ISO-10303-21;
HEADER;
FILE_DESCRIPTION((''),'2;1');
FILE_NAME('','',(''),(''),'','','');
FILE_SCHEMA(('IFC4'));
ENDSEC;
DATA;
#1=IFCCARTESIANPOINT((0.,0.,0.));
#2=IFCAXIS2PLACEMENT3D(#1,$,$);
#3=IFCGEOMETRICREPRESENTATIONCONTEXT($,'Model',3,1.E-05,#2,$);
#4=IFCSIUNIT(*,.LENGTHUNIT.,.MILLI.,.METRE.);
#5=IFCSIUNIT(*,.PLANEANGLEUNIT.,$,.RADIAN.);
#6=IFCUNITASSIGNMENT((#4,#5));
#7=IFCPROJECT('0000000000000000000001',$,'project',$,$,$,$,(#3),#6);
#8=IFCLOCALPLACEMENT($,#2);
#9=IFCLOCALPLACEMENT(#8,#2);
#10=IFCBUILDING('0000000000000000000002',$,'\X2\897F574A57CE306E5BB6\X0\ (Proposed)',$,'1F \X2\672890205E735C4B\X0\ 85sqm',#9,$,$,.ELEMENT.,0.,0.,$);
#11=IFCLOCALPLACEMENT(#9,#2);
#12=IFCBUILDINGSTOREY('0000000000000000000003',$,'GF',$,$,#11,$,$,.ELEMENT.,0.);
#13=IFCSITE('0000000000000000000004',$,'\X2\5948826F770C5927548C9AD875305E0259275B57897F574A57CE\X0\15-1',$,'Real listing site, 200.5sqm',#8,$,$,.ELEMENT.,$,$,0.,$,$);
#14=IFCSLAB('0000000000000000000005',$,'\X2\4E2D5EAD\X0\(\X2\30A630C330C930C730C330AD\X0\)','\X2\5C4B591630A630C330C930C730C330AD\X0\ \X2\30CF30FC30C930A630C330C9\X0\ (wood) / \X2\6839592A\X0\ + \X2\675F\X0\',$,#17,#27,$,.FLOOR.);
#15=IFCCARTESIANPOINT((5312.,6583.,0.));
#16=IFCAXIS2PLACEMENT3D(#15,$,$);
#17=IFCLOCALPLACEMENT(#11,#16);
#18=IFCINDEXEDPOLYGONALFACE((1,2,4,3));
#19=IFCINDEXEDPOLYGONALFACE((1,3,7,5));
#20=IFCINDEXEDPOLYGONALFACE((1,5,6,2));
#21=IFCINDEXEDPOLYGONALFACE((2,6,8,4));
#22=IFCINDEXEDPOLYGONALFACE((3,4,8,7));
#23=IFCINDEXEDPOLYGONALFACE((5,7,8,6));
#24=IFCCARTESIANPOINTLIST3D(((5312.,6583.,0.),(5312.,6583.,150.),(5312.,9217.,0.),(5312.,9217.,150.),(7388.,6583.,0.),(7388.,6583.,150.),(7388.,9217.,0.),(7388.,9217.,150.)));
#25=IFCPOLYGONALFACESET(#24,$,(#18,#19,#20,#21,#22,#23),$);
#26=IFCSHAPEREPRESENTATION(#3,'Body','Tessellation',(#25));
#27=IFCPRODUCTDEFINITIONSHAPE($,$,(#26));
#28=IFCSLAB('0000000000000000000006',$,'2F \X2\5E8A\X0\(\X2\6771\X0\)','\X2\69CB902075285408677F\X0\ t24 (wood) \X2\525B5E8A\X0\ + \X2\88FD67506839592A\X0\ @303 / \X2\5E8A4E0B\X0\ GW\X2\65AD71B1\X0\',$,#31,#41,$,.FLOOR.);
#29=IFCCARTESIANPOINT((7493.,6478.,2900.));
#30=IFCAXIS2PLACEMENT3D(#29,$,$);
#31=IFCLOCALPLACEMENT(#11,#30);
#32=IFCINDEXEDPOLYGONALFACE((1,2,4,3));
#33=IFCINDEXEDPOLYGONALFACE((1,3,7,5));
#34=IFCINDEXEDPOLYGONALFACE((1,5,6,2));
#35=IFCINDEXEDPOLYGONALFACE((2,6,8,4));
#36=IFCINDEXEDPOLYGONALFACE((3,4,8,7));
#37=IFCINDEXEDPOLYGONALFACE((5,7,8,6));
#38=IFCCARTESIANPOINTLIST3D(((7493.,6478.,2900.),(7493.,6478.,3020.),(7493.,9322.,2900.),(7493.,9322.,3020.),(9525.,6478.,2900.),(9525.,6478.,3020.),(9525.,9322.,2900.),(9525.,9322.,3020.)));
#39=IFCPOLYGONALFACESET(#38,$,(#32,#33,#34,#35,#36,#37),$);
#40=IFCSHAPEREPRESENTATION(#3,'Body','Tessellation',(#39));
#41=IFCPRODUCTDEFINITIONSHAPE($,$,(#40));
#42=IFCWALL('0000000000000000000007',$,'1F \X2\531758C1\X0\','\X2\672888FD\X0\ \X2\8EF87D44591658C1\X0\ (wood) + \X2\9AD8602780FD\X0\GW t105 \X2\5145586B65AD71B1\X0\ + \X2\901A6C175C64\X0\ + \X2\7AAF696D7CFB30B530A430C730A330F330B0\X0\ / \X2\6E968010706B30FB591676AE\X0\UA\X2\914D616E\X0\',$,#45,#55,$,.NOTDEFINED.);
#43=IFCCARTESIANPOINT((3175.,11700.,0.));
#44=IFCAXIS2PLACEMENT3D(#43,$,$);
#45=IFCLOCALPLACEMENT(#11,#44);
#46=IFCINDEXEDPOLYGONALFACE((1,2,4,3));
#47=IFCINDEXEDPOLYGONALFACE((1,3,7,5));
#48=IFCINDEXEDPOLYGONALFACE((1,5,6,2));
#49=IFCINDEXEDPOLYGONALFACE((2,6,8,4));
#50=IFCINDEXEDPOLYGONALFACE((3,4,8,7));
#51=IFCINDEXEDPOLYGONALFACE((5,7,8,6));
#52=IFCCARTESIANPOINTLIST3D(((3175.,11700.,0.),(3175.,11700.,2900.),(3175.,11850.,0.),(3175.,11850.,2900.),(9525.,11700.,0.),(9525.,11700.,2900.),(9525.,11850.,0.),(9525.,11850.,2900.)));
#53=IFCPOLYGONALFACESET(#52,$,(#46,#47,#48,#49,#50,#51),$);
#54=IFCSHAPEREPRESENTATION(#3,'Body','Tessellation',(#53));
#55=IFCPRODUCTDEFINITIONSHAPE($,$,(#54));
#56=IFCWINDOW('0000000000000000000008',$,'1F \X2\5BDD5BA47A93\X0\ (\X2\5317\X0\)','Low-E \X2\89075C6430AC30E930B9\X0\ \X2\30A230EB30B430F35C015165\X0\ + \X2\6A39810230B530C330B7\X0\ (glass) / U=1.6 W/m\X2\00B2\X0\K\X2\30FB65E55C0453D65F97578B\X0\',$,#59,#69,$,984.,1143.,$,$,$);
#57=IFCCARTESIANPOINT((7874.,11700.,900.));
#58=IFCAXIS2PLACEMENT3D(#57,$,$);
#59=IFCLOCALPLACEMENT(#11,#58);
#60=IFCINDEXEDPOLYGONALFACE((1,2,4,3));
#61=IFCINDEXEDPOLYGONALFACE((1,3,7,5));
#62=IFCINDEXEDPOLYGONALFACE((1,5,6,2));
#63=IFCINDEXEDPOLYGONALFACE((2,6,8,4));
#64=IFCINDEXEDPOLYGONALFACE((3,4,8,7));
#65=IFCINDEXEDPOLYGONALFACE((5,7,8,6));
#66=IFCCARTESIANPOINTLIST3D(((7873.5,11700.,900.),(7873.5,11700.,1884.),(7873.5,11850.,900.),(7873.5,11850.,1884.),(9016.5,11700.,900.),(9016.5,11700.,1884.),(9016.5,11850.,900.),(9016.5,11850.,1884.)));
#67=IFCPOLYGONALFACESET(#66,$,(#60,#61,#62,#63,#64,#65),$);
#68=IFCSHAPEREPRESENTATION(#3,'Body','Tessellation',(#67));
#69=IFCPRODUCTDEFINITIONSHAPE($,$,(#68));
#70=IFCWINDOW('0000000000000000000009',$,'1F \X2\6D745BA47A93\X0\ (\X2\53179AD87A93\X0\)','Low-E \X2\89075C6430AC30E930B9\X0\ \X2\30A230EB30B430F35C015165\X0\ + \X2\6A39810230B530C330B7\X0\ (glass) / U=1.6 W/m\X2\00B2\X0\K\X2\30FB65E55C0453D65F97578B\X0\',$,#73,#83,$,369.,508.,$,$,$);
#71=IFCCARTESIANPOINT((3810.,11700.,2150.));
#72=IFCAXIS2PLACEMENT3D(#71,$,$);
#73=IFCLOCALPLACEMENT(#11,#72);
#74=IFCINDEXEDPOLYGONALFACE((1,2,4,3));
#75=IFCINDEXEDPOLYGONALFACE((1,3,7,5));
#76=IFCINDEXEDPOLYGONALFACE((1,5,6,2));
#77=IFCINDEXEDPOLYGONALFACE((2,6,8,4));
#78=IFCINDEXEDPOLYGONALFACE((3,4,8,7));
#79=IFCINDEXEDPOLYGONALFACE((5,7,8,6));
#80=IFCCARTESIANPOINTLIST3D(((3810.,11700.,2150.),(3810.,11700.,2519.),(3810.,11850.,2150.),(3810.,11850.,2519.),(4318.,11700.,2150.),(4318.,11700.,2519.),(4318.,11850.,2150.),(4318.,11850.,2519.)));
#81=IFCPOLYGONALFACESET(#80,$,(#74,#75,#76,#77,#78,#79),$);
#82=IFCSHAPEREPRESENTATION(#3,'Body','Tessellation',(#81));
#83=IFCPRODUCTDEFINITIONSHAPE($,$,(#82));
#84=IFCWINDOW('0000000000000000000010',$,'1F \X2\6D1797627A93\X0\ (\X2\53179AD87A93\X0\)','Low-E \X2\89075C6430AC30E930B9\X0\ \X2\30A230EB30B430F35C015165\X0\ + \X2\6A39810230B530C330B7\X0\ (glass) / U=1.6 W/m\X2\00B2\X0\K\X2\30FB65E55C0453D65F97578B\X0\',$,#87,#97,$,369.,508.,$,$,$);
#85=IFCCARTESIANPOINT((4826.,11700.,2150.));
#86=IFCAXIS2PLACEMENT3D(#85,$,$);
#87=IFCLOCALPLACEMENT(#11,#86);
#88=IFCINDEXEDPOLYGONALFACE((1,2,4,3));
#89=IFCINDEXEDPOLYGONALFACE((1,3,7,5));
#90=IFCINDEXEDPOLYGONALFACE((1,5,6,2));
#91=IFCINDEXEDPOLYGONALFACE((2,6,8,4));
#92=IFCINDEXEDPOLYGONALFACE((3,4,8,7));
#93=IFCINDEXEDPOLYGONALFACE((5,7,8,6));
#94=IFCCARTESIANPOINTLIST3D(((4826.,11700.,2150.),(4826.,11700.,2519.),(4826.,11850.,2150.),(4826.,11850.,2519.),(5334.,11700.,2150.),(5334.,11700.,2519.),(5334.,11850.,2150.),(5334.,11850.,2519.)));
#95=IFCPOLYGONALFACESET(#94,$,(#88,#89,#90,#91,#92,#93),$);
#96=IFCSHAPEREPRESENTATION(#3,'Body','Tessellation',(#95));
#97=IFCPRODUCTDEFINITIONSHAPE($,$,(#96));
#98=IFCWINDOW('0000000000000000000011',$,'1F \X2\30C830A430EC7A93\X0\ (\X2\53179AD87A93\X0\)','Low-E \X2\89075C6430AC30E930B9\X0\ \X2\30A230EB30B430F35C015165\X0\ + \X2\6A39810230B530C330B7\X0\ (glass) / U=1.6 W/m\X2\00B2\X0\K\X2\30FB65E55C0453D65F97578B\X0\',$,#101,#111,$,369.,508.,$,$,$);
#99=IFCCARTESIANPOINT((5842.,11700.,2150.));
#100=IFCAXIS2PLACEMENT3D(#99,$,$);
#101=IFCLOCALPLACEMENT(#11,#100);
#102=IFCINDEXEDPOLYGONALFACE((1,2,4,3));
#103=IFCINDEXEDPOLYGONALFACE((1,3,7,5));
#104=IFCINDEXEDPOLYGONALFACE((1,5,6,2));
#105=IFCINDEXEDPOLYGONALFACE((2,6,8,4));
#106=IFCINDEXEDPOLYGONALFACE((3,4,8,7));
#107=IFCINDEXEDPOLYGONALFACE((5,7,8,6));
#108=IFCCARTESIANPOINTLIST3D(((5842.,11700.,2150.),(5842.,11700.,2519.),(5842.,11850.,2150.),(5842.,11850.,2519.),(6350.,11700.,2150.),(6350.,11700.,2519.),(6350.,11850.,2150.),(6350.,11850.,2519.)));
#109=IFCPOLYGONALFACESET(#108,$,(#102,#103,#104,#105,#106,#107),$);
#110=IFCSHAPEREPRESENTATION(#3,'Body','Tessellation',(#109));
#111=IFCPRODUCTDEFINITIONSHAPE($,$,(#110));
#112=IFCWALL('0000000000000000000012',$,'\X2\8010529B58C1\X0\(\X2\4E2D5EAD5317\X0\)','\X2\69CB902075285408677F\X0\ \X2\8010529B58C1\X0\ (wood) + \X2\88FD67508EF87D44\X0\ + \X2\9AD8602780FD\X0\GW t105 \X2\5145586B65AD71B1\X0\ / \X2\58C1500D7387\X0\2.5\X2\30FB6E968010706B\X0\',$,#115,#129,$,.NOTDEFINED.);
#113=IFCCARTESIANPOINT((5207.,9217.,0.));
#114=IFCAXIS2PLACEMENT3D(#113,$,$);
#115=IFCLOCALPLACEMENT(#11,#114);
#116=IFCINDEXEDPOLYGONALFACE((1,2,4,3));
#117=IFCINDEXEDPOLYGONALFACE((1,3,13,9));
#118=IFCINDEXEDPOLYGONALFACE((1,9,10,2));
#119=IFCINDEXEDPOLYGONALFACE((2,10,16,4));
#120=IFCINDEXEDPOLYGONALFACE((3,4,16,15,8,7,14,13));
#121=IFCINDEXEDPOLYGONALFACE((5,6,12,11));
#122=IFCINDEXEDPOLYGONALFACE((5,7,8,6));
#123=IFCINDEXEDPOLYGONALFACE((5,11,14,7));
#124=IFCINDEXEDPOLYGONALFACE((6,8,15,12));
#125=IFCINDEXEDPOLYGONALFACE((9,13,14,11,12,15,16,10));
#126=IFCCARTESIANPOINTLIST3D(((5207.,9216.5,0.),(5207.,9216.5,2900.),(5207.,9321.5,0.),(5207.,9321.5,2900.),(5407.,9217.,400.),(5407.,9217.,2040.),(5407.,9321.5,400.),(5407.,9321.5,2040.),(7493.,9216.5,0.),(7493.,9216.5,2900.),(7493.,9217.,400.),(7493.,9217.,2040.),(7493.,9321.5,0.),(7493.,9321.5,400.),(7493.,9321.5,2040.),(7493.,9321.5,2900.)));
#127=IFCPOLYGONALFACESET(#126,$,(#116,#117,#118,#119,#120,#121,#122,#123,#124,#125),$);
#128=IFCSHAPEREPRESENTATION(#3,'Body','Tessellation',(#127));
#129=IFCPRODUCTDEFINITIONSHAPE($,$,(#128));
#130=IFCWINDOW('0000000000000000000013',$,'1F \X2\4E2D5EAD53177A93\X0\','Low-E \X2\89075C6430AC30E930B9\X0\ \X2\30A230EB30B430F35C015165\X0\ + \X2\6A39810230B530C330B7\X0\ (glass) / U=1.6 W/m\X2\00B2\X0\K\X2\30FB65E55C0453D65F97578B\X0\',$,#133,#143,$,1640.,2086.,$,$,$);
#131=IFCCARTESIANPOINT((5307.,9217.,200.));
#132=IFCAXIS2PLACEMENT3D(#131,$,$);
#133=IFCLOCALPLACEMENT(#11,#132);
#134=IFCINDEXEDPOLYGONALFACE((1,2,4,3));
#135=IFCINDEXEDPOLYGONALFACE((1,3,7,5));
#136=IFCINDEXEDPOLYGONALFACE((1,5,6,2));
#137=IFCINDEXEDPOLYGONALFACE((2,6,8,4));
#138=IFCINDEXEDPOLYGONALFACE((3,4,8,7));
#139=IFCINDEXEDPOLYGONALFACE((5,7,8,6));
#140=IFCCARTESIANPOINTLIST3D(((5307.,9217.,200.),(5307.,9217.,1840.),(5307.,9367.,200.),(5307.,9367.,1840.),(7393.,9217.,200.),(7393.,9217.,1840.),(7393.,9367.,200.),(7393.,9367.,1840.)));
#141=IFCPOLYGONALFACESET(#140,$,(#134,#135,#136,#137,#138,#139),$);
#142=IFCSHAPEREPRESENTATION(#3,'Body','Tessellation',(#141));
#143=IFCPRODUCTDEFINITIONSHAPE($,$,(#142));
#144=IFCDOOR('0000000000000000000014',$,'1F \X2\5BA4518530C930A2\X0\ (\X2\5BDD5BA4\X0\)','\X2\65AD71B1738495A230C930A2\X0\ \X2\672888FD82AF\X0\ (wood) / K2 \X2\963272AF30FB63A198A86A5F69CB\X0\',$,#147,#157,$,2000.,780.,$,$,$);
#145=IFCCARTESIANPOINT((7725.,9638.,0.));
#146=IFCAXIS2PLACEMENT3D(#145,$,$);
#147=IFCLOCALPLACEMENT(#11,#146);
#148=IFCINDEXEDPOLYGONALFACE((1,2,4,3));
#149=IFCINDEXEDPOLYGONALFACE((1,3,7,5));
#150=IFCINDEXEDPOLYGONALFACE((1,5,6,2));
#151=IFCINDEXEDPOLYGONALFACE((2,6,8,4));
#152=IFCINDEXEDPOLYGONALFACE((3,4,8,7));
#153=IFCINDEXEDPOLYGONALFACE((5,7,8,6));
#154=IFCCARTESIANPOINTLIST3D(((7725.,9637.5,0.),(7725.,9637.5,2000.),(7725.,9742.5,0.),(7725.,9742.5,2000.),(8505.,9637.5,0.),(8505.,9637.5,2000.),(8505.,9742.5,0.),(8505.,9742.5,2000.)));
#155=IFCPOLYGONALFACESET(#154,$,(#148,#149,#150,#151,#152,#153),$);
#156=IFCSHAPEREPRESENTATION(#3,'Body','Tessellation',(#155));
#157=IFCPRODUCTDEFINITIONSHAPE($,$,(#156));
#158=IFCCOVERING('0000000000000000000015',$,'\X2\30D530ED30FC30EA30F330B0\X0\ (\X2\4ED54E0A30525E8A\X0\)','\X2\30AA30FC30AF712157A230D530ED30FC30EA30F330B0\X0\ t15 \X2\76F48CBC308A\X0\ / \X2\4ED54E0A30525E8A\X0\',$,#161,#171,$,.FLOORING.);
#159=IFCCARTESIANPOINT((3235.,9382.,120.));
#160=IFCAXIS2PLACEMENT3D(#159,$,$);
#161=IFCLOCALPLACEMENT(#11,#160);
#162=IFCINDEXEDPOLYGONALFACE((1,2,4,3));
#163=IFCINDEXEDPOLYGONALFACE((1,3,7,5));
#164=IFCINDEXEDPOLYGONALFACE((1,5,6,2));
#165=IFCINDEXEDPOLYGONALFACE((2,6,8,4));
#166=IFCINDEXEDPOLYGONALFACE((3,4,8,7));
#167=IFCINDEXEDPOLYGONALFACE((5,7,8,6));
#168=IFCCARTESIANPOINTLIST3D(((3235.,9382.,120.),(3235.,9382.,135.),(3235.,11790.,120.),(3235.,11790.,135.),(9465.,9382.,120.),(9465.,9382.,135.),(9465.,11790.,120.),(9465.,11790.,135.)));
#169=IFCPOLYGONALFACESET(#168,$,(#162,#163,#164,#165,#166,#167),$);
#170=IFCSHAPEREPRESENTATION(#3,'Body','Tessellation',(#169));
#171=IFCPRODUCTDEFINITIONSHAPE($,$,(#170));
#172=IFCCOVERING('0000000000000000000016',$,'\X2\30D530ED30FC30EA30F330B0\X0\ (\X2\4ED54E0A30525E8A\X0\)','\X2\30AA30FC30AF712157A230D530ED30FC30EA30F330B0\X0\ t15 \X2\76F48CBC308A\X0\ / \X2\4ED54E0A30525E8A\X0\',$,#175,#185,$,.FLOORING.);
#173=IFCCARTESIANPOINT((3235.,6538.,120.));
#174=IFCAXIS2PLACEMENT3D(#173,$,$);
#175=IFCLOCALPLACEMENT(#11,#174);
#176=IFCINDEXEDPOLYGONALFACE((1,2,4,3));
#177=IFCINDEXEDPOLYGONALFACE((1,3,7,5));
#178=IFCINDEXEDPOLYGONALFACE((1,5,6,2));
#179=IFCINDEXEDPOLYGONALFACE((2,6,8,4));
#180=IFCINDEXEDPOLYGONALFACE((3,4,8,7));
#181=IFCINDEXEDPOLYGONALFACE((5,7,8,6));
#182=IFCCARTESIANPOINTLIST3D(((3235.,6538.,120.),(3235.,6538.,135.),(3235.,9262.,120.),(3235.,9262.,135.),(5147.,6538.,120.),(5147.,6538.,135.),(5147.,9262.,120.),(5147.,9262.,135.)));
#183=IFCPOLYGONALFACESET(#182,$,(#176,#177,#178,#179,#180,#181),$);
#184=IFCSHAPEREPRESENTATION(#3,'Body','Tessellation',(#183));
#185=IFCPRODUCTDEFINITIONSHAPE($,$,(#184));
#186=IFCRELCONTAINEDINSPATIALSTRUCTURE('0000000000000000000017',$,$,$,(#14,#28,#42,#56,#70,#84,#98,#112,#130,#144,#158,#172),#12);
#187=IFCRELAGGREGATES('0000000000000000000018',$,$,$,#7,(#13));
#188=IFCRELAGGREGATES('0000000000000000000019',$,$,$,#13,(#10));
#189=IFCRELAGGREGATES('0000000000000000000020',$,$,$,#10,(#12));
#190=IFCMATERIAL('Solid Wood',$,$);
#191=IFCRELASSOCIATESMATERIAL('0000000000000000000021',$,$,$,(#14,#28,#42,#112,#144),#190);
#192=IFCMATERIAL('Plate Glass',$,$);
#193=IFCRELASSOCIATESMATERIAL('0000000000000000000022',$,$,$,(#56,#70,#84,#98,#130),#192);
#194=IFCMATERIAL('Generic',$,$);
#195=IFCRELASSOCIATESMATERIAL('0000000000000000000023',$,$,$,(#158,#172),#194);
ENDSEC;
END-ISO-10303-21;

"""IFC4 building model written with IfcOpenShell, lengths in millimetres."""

from ifc_helpers import new_model, si_unit, frame, frame_2d, origin, place, context, project, spatial, rectangle, extrude, material, element, fill, save


model = new_model("IFC4")

# Units and contexts
model_context = context("Model", 3, precision=1e-05, world=origin())
ifc_project = project(units=[si_unit("LENGTHUNIT", "METRE", prefix="MILLI"), si_unit("PLANEANGLEUNIT", "RADIAN")], contexts=[model_context])

# Site, building, storey
site_placement = place(None, origin())
site = spatial("IfcSite", under=ifc_project, at=site_placement, Name="奈良県大和高田市大字西坊城15-1", ObjectType="Real listing site, 200.5sqm", CompositionType="ELEMENT", RefElevation=0.0)
building_placement = place(site_placement, origin())
building = spatial("IfcBuilding", under=site, at=building_placement, Name="西坊城の家 (Proposed)", ObjectType="1F 木造平屋 85sqm", CompositionType="ELEMENT", ElevationOfRefHeight=0.0, ElevationOfTerrain=0.0)
storey_placement = place(building_placement, origin())
storey = spatial("IfcBuildingStorey", under=building, at=storey_placement, Name="GF", CompositionType="ELEMENT", Elevation=0.0)

# Slabs
ifc_material_1 = material(Name="Solid Wood")
slab_1_placement = place(storey_placement, frame((5312.0, 6583.0, 0.0)))
element("IfcSlab", 1, at=slab_1_placement, inside=storey, material=ifc_material_1, Name="中庭(ウッドデッキ)", Description="屋外ウッドデッキ ハードウッド (wood) / 根太 + 束", PredefinedType="FLOOR", context=model_context, shape_type="SweptSolid", body=[
    extrude(rectangle(XDim=2076.0, YDim=2634.0, at=frame_2d((1038.0, 1317.0))), frame((5312.0, 6583.0, 0.0)), (0.0, 0.0, 1.0), 150.0),
])
slab_2_placement = place(storey_placement, frame((7493.0, 6478.0, 2900.0)))
element("IfcSlab", 2, at=slab_2_placement, inside=storey, material=ifc_material_1, Name="2F 床(東)", Description="構造用合板 t24 (wood) 剛床 + 製材根太 @303 / 床下 GW断熱", PredefinedType="FLOOR", context=model_context, shape_type="SweptSolid", body=[
    extrude(rectangle(XDim=2032.0, YDim=2844.0, at=frame_2d((1016.0, 1422.0))), frame((7493.0, 6478.0, 2900.0)), (0.0, 0.0, 1.0), 120.0),
])

# Wall, openings, windows
wall_1_placement = place(storey_placement, frame((3175.0, 11700.0, 0.0)))
wall_1 = element("IfcWall", 3, at=wall_1_placement, inside=storey, material=ifc_material_1, Name="1F 北壁", Description="木製 軸組外壁 (wood) + 高性能GW t105 充填断熱 + 通気層 + 窯業系サイディング / 準耐火・外皮UA配慮", PredefinedType="NOTDEFINED", context=model_context, shape_type="SweptSolid", body=[
    extrude(rectangle(XDim=6350.0, YDim=150.0, at=frame_2d((3175.0, 75.0))), frame((3175.0, 11700.0, 0.0)), (0.0, 0.0, 1.0), 2900.0),
])
opening_1_placement = place(storey_placement, frame((7874.0, 11700.0, 900.0)))
opening_1 = element("IfcOpeningElement", 4, at=opening_1_placement, cuts=wall_1, PredefinedType="NOTDEFINED", context=model_context, shape_type="SweptSolid", body=[
    extrude(rectangle(XDim=1143.0, YDim=150.0, at=frame_2d((571.0, 75.0))), frame((7874.0, 11700.0, 900.0)), (0.0, 0.0, 1.0), 984.0),
])
opening_2_placement = place(storey_placement, frame((3810.0, 11700.0, 2150.0)))
opening_2 = element("IfcOpeningElement", 5, at=opening_2_placement, cuts=wall_1, PredefinedType="NOTDEFINED", context=model_context, shape_type="SweptSolid", body=[
    extrude(rectangle(XDim=508.0, YDim=150.0, at=frame_2d((254.0, 75.0))), frame((3810.0, 11700.0, 2150.0)), (0.0, 0.0, 1.0), 369.0),
])
opening_3_placement = place(storey_placement, frame((4826.0, 11700.0, 2150.0)))
opening_3 = element("IfcOpeningElement", 6, at=opening_3_placement, cuts=wall_1, PredefinedType="NOTDEFINED", context=model_context, shape_type="SweptSolid", body=[
    extrude(rectangle(XDim=508.0, YDim=150.0, at=frame_2d((254.0, 75.0))), frame((4826.0, 11700.0, 2150.0)), (0.0, 0.0, 1.0), 369.0),
])
opening_4_placement = place(storey_placement, frame((5842.0, 11700.0, 2150.0)))
opening_4 = element("IfcOpeningElement", 7, at=opening_4_placement, cuts=wall_1, PredefinedType="NOTDEFINED", context=model_context, shape_type="SweptSolid", body=[
    extrude(rectangle(XDim=508.0, YDim=150.0, at=frame_2d((254.0, 75.0))), frame((5842.0, 11700.0, 2150.0)), (0.0, 0.0, 1.0), 369.0),
])
ifc_material_2 = material(Name="Plate Glass")
window_1_placement = place(storey_placement, frame((7874.0, 11700.0, 900.0)))
window_1 = element("IfcWindow", 8, at=window_1_placement, inside=storey, material=ifc_material_2, Name="1F 寝室窓 (北)", Description="Low-E 複層ガラス アルゴン封入 + 樹脂サッシ (glass) / U=1.6 W/m²K・日射取得型", OverallHeight=984.0, OverallWidth=1143.0, context=model_context, shape_type="SweptSolid", body=[
    extrude(rectangle(XDim=1143.0, YDim=150.0, at=frame_2d((571.0, 75.0))), frame((7874.0, 11700.0, 900.0)), (0.0, 0.0, 1.0), 984.0),
])
fill(opening_1, window_1)
window_2_placement = place(storey_placement, frame((3810.0, 11700.0, 2150.0)))
window_2 = element("IfcWindow", 9, at=window_2_placement, inside=storey, material=ifc_material_2, Name="1F 浴室窓 (北高窓)", Description="Low-E 複層ガラス アルゴン封入 + 樹脂サッシ (glass) / U=1.6 W/m²K・日射取得型", OverallHeight=369.0, OverallWidth=508.0, context=model_context, shape_type="SweptSolid", body=[
    extrude(rectangle(XDim=508.0, YDim=150.0, at=frame_2d((254.0, 75.0))), frame((3810.0, 11700.0, 2150.0)), (0.0, 0.0, 1.0), 369.0),
])
fill(opening_2, window_2)
window_3_placement = place(storey_placement, frame((4826.0, 11700.0, 2150.0)))
window_3 = element("IfcWindow", 10, at=window_3_placement, inside=storey, material=ifc_material_2, Name="1F 洗面窓 (北高窓)", Description="Low-E 複層ガラス アルゴン封入 + 樹脂サッシ (glass) / U=1.6 W/m²K・日射取得型", OverallHeight=369.0, OverallWidth=508.0, context=model_context, shape_type="SweptSolid", body=[
    extrude(rectangle(XDim=508.0, YDim=150.0, at=frame_2d((254.0, 75.0))), frame((4826.0, 11700.0, 2150.0)), (0.0, 0.0, 1.0), 369.0),
])
fill(opening_3, window_3)
window_4_placement = place(storey_placement, frame((5842.0, 11700.0, 2150.0)))
window_4 = element("IfcWindow", 11, at=window_4_placement, inside=storey, material=ifc_material_2, Name="1F トイレ窓 (北高窓)", Description="Low-E 複層ガラス アルゴン封入 + 樹脂サッシ (glass) / U=1.6 W/m²K・日射取得型", OverallHeight=369.0, OverallWidth=508.0, context=model_context, shape_type="SweptSolid", body=[
    extrude(rectangle(XDim=508.0, YDim=150.0, at=frame_2d((254.0, 75.0))), frame((5842.0, 11700.0, 2150.0)), (0.0, 0.0, 1.0), 369.0),
])
fill(opening_4, window_4)

# Wall, opening, window
wall_2_placement = place(storey_placement, frame((5207.0, 9217.0, 0.0)))
wall_2 = element("IfcWall", 12, at=wall_2_placement, inside=storey, material=ifc_material_1, Name="耐力壁(中庭北)", Description="構造用合板 耐力壁 (wood) + 製材軸組 + 高性能GW t105 充填断熱 / 壁倍率2.5・準耐火", PredefinedType="NOTDEFINED", context=model_context, shape_type="SweptSolid", body=[
    extrude(rectangle(XDim=2286.0, YDim=105.0, at=frame_2d((1143.0, 52.0))), frame((5207.0, 9217.0, 0.0)), (0.0, 0.0, 1.0), 2900.0),
])
opening_5_placement = place(storey_placement, frame((5307.0, 9217.0, 200.0)))
opening_5 = element("IfcOpeningElement", 13, at=opening_5_placement, cuts=wall_2, PredefinedType="NOTDEFINED", context=model_context, shape_type="SweptSolid", body=[
    extrude(rectangle(XDim=2086.0, YDim=150.0, at=frame_2d((1043.0, 75.0))), frame((5307.0, 9217.0, 200.0)), (0.0, 0.0, 1.0), 1640.0),
])
window_5_placement = place(storey_placement, frame((5307.0, 9217.0, 200.0)))
window_5 = element("IfcWindow", 14, at=window_5_placement, inside=storey, material=ifc_material_2, Name="1F 中庭北窓", Description="Low-E 複層ガラス アルゴン封入 + 樹脂サッシ (glass) / U=1.6 W/m²K・日射取得型", OverallHeight=1640.0, OverallWidth=2086.0, context=model_context, shape_type="SweptSolid", body=[
    extrude(rectangle(XDim=2086.0, YDim=150.0, at=frame_2d((1043.0, 75.0))), frame((5307.0, 9217.0, 200.0)), (0.0, 0.0, 1.0), 1640.0),
])
fill(opening_5, window_5)

# Door
door_1_placement = place(storey_placement, frame((7725.0, 9638.0, 0.0)))
element("IfcDoor", 15, at=door_1_placement, inside=storey, material=ifc_material_1, Name="1F 室内ドア (寝室)", Description="断熱玄関ドア 木製芯 (wood) / K2 防犯・採風機構", OverallHeight=2000.0, OverallWidth=780.0, context=model_context, shape_type="SweptSolid", body=[
    extrude(rectangle(XDim=780.0, YDim=105.0, at=frame_2d((390.0, 52.0))), frame((7725.0, 9638.0, 0.0)), (0.0, 0.0, 1.0), 2000.0),
])

# Coverings
ifc_material_3 = material(Name="Generic")
covering_1_placement = place(storey_placement, frame((3235.0, 9382.0, 120.0)))
element("IfcCovering", 16, at=covering_1_placement, inside=storey, material=ifc_material_3, Name="フローリング (仕上げ床)", Description="オーク無垢フローリング t15 直貼り / 仕上げ床", PredefinedType="FLOORING", context=model_context, shape_type="SweptSolid", body=[
    extrude(rectangle(XDim=6230.0, YDim=2408.0, at=frame_2d((3115.0, 1204.0))), frame((3235.0, 9382.0, 120.0)), (0.0, 0.0, 1.0), 15.0),
])
covering_2_placement = place(storey_placement, frame((3235.0, 6538.0, 120.0)))
element("IfcCovering", 17, at=covering_2_placement, inside=storey, material=ifc_material_3, Name="フローリング (仕上げ床)", Description="オーク無垢フローリング t15 直貼り / 仕上げ床", PredefinedType="FLOORING", context=model_context, shape_type="SweptSolid", body=[
    extrude(rectangle(XDim=1912.0, YDim=2724.0, at=frame_2d((956.0, 1362.0))), frame((3235.0, 6538.0, 120.0)), (0.0, 0.0, 1.0), 15.0),
])

save(model, "model.ifc")
